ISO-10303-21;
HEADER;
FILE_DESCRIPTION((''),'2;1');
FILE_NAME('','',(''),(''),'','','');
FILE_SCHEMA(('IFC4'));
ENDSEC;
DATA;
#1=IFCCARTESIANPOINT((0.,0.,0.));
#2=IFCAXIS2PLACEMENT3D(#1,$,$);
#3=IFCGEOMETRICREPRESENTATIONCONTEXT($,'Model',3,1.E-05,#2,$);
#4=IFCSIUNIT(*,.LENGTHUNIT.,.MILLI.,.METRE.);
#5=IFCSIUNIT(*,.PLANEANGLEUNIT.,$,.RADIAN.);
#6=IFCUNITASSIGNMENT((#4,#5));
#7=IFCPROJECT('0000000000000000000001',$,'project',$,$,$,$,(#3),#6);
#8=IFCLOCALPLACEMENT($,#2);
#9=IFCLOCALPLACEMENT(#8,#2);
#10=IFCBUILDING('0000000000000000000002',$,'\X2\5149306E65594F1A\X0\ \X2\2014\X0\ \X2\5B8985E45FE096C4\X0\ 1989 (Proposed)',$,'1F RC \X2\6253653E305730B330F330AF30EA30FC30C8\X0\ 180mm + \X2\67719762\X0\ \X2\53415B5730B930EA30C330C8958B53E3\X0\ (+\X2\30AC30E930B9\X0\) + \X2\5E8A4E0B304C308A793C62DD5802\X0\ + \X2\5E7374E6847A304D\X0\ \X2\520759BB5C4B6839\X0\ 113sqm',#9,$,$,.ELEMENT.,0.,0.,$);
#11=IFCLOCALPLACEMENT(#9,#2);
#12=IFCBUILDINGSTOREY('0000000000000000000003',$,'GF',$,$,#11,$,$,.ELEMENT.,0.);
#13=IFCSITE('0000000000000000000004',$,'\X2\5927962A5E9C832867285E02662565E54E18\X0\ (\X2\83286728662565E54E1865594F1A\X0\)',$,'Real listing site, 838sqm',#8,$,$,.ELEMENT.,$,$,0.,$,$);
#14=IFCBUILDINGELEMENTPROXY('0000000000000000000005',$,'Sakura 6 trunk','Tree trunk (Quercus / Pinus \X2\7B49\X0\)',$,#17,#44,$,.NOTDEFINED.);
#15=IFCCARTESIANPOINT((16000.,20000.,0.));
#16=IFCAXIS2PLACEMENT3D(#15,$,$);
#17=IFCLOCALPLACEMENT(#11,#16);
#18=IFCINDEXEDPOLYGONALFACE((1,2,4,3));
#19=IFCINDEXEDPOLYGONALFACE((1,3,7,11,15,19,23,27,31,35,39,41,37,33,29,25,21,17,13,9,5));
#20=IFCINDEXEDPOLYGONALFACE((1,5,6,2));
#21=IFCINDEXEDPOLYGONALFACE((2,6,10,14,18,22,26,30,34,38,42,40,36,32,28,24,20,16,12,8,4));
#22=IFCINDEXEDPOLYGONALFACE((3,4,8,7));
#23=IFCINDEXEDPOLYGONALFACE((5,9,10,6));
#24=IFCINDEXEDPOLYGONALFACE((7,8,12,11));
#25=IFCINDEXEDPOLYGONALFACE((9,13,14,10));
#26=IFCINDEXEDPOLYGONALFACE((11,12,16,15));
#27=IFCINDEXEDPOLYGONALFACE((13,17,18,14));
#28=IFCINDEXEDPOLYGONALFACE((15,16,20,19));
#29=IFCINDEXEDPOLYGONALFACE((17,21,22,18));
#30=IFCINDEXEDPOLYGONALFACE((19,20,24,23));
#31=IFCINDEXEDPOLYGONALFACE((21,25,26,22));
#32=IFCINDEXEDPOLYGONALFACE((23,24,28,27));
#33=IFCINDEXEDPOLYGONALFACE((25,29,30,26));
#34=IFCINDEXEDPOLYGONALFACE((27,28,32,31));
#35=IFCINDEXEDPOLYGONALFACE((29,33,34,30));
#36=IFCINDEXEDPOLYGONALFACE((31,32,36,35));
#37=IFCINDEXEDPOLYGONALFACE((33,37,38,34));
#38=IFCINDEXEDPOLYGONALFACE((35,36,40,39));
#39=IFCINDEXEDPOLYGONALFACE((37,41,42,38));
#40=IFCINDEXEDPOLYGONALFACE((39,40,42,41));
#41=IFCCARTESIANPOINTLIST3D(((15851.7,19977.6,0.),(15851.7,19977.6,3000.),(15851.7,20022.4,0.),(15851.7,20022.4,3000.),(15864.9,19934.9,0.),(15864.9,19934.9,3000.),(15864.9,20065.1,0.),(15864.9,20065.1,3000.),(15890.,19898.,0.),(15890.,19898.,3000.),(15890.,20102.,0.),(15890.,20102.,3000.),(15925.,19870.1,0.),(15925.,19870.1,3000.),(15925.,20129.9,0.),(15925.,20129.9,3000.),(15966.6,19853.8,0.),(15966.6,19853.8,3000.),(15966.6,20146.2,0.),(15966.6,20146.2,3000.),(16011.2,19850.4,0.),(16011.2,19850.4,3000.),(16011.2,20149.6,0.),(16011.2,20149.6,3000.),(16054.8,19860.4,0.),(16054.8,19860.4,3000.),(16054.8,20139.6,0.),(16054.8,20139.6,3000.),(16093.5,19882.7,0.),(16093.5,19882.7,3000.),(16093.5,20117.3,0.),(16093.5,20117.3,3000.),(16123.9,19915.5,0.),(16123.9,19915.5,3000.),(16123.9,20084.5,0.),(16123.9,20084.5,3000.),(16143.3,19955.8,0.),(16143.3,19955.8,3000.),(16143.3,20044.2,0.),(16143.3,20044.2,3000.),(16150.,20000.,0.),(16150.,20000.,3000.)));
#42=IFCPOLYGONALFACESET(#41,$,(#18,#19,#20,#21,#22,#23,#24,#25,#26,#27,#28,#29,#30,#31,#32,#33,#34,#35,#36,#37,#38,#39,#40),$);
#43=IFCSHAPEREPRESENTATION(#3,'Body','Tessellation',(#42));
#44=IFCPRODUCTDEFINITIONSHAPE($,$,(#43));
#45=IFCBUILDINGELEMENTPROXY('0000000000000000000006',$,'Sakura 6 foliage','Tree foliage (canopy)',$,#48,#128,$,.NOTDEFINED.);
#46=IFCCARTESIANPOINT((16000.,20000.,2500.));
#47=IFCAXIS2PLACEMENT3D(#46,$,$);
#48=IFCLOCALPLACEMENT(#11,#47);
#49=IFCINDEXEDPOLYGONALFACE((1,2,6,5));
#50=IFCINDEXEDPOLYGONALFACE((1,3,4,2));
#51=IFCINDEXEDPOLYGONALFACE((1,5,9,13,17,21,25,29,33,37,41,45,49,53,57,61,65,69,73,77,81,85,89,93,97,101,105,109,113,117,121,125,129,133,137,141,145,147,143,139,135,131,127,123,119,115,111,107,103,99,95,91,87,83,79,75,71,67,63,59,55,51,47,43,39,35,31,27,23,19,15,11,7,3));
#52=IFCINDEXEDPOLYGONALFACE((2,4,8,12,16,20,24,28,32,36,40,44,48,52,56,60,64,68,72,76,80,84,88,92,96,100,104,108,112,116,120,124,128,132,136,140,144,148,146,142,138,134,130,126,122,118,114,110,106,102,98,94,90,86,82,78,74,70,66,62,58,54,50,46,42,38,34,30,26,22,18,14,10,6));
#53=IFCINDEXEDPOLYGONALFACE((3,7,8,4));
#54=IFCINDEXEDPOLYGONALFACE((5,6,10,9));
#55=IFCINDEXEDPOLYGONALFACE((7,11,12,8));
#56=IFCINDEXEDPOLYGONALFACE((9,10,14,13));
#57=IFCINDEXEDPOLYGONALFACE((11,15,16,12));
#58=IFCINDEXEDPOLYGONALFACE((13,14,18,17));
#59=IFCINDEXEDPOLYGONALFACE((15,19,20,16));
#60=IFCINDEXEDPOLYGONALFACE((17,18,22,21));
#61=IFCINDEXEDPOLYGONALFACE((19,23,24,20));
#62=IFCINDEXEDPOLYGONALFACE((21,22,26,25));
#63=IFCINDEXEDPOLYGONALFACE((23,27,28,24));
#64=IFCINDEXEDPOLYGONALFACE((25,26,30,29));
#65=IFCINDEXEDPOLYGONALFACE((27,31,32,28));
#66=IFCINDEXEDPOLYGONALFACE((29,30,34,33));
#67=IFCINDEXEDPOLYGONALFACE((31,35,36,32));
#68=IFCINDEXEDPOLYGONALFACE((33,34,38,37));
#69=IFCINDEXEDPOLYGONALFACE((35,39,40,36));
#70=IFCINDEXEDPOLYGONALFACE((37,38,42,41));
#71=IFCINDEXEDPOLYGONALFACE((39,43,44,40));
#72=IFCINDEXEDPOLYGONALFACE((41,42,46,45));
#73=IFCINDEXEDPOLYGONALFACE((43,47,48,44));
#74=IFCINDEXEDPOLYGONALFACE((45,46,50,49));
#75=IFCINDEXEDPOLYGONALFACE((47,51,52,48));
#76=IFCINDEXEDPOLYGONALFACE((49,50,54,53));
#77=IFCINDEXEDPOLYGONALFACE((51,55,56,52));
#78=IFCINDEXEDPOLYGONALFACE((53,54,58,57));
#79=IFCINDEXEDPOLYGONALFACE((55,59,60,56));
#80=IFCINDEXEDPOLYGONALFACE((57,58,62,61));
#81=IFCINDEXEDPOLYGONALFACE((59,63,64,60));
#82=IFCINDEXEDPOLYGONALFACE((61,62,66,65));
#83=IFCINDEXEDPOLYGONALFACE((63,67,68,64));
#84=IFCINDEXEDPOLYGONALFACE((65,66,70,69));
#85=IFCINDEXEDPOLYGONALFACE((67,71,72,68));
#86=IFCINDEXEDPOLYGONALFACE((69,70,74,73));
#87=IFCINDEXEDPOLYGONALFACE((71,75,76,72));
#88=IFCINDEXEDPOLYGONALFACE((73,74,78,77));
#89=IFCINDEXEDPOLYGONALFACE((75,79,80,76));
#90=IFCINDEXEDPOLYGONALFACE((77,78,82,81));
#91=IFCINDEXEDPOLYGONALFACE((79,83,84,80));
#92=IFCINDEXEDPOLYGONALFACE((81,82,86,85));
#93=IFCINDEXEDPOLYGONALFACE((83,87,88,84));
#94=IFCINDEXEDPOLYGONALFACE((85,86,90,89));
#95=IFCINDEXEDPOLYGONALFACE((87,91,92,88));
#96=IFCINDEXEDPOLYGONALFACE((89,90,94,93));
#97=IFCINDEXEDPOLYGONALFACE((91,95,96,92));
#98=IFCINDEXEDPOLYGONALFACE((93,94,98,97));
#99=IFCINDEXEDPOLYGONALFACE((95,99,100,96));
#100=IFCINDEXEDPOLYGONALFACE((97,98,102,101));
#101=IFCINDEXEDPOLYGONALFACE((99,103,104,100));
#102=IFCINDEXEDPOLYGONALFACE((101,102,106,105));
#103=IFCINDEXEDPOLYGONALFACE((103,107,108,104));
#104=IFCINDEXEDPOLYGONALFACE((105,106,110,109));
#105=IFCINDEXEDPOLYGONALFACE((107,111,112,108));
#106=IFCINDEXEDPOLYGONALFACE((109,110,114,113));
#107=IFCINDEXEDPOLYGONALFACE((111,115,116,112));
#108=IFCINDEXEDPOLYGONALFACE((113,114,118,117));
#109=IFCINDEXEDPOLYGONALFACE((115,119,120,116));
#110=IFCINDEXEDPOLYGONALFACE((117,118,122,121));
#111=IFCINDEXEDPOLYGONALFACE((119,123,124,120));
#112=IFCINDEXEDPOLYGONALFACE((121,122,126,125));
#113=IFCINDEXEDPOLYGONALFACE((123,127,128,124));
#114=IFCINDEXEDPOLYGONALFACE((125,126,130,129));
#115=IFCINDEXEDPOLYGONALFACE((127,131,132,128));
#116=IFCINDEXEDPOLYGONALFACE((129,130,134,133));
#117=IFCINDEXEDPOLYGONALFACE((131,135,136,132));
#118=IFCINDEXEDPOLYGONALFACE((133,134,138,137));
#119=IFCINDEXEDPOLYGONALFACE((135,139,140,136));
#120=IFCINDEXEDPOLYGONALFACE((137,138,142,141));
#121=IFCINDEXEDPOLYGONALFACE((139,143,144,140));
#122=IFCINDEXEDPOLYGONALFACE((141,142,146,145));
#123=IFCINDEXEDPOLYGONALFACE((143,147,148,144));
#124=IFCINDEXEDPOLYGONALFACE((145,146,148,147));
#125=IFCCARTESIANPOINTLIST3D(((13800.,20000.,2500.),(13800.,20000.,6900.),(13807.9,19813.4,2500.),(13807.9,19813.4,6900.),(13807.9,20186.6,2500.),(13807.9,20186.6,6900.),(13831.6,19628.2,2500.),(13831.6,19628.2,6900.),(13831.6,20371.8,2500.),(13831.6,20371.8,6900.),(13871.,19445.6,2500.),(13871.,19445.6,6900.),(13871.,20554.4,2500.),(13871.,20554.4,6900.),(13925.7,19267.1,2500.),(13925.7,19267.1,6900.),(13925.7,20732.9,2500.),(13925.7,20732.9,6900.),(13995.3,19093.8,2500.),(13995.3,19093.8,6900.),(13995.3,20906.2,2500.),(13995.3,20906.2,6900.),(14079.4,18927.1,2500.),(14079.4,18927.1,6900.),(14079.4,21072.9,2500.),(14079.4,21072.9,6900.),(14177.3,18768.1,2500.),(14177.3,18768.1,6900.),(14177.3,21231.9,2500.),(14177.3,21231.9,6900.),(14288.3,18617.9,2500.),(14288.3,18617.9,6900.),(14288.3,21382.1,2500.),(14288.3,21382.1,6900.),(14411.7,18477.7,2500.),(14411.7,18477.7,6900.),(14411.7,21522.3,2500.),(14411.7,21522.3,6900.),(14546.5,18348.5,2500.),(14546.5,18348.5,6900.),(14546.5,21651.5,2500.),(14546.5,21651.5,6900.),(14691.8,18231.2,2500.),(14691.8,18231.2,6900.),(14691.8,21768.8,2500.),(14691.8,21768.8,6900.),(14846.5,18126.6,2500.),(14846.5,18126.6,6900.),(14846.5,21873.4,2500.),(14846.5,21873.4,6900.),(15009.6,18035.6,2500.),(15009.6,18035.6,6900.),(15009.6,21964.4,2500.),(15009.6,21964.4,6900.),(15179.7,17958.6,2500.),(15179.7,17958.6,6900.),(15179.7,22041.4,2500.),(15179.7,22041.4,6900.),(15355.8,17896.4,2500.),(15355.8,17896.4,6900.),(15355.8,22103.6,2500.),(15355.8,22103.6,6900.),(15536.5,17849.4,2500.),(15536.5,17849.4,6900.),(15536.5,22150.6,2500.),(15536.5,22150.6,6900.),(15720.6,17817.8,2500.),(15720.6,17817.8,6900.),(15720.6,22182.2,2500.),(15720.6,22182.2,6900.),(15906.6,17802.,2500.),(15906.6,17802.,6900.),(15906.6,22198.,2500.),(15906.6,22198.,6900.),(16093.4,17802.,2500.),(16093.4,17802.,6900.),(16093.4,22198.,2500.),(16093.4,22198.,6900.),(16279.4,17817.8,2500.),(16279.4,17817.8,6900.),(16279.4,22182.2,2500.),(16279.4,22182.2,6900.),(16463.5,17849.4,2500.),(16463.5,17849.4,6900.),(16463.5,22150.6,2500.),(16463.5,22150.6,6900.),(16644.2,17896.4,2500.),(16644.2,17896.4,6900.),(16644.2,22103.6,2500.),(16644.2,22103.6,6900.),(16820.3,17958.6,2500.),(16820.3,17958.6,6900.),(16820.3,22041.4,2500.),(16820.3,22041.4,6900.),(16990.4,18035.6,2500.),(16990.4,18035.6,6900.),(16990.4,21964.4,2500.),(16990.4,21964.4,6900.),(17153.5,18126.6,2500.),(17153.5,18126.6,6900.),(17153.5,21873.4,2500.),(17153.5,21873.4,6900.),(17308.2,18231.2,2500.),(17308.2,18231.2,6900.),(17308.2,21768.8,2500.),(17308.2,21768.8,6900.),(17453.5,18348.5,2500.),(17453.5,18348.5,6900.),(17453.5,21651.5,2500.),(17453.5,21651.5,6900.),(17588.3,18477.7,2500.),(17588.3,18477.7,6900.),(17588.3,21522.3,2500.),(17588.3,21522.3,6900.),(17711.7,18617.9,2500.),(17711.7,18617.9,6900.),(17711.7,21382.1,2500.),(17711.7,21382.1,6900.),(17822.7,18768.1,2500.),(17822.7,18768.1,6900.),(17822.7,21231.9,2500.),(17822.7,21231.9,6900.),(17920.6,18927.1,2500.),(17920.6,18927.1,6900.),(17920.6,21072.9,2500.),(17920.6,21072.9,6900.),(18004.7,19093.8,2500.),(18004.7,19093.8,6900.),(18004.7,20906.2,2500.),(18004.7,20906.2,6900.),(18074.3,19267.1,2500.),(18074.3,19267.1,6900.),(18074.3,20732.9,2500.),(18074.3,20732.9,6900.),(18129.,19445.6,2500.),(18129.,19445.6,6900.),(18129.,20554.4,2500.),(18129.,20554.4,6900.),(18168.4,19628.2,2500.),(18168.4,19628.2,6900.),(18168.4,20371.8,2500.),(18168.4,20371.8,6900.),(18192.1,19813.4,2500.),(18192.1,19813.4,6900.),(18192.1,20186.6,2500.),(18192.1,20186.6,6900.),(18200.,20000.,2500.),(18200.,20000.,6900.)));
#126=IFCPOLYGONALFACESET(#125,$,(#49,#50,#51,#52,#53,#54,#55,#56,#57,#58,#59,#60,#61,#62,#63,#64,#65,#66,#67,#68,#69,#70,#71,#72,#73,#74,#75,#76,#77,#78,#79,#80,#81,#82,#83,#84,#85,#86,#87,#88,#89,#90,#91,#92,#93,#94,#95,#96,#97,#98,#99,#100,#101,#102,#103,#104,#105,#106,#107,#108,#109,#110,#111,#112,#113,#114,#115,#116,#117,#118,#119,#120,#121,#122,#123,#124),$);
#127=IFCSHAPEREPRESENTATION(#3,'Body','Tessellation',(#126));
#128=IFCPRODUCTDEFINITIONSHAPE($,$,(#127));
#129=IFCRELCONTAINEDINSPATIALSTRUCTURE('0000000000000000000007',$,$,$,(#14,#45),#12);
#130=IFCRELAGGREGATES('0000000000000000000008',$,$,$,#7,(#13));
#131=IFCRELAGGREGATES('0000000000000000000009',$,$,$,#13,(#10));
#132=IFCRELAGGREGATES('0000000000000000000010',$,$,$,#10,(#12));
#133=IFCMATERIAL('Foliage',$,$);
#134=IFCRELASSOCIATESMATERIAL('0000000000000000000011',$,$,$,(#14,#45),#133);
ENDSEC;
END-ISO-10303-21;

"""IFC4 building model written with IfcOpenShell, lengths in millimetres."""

from ifc_helpers import new_model, si_unit, frame, origin, origin_2d, place, context, project, spatial, circle, extrude, material, element, save


model = new_model("IFC4")

# Units and contexts
model_context = context("Model", 3, precision=1e-05, world=origin())
ifc_project = project(units=[si_unit("LENGTHUNIT", "METRE", prefix="MILLI"), si_unit("PLANEANGLEUNIT", "RADIAN")], contexts=[model_context])

# Site, building, storey
site_placement = place(None, origin())
site = spatial("IfcSite", under=ifc_project, at=site_placement, Name="大阪府茨木市春日丘 (茨木春日丘教会)", ObjectType="Real listing site, 838sqm", CompositionType="ELEMENT", RefElevation=0.0)
building_placement = place(site_placement, origin())
building = spatial("IfcBuilding", under=site, at=building_placement, Name="光の教会 — 安藤忠雄 1989 (Proposed)", ObjectType="1F RC 打放しコンクリート 180mm + 東面 十字スリット開口 (+ガラス) + 床下がり礼拝堂 + 平瓦葺き 切妻屋根 113sqm", CompositionType="ELEMENT", ElevationOfRefHeight=0.0, ElevationOfTerrain=0.0)
storey_placement = place(building_placement, origin())
storey = spatial("IfcBuildingStorey", under=building, at=storey_placement, Name="GF", CompositionType="ELEMENT", Elevation=0.0)

# Building element proxies
ifc_material_1 = material(Name="Foliage")
proxy_1_placement = place(storey_placement, frame((16000.0, 20000.0, 0.0)))
element("IfcBuildingElementProxy", 1, at=proxy_1_placement, inside=storey, material=ifc_material_1, Name="Sakura 6 trunk", Description="Tree trunk (Quercus / Pinus 等)", PredefinedType="NOTDEFINED", context=model_context, shape_type="SweptSolid", body=[
    extrude(circle(Radius=150.0, at=origin_2d()), frame((16000.0, 20000.0, 0.0)), (0.0, 0.0, 1.0), 3000.0),
])
proxy_2_placement = place(storey_placement, frame((16000.0, 20000.0, 2500.0)))
element("IfcBuildingElementProxy", 2, at=proxy_2_placement, inside=storey, material=ifc_material_1, Name="Sakura 6 foliage", Description="Tree foliage (canopy)", PredefinedType="NOTDEFINED", context=model_context, shape_type="SweptSolid", body=[
    extrude(circle(Radius=2200.0, at=origin_2d()), frame((16000.0, 20000.0, 2500.0)), (0.0, 0.0, 1.0), 4400.0),
])

save(model, "model.ifc")
